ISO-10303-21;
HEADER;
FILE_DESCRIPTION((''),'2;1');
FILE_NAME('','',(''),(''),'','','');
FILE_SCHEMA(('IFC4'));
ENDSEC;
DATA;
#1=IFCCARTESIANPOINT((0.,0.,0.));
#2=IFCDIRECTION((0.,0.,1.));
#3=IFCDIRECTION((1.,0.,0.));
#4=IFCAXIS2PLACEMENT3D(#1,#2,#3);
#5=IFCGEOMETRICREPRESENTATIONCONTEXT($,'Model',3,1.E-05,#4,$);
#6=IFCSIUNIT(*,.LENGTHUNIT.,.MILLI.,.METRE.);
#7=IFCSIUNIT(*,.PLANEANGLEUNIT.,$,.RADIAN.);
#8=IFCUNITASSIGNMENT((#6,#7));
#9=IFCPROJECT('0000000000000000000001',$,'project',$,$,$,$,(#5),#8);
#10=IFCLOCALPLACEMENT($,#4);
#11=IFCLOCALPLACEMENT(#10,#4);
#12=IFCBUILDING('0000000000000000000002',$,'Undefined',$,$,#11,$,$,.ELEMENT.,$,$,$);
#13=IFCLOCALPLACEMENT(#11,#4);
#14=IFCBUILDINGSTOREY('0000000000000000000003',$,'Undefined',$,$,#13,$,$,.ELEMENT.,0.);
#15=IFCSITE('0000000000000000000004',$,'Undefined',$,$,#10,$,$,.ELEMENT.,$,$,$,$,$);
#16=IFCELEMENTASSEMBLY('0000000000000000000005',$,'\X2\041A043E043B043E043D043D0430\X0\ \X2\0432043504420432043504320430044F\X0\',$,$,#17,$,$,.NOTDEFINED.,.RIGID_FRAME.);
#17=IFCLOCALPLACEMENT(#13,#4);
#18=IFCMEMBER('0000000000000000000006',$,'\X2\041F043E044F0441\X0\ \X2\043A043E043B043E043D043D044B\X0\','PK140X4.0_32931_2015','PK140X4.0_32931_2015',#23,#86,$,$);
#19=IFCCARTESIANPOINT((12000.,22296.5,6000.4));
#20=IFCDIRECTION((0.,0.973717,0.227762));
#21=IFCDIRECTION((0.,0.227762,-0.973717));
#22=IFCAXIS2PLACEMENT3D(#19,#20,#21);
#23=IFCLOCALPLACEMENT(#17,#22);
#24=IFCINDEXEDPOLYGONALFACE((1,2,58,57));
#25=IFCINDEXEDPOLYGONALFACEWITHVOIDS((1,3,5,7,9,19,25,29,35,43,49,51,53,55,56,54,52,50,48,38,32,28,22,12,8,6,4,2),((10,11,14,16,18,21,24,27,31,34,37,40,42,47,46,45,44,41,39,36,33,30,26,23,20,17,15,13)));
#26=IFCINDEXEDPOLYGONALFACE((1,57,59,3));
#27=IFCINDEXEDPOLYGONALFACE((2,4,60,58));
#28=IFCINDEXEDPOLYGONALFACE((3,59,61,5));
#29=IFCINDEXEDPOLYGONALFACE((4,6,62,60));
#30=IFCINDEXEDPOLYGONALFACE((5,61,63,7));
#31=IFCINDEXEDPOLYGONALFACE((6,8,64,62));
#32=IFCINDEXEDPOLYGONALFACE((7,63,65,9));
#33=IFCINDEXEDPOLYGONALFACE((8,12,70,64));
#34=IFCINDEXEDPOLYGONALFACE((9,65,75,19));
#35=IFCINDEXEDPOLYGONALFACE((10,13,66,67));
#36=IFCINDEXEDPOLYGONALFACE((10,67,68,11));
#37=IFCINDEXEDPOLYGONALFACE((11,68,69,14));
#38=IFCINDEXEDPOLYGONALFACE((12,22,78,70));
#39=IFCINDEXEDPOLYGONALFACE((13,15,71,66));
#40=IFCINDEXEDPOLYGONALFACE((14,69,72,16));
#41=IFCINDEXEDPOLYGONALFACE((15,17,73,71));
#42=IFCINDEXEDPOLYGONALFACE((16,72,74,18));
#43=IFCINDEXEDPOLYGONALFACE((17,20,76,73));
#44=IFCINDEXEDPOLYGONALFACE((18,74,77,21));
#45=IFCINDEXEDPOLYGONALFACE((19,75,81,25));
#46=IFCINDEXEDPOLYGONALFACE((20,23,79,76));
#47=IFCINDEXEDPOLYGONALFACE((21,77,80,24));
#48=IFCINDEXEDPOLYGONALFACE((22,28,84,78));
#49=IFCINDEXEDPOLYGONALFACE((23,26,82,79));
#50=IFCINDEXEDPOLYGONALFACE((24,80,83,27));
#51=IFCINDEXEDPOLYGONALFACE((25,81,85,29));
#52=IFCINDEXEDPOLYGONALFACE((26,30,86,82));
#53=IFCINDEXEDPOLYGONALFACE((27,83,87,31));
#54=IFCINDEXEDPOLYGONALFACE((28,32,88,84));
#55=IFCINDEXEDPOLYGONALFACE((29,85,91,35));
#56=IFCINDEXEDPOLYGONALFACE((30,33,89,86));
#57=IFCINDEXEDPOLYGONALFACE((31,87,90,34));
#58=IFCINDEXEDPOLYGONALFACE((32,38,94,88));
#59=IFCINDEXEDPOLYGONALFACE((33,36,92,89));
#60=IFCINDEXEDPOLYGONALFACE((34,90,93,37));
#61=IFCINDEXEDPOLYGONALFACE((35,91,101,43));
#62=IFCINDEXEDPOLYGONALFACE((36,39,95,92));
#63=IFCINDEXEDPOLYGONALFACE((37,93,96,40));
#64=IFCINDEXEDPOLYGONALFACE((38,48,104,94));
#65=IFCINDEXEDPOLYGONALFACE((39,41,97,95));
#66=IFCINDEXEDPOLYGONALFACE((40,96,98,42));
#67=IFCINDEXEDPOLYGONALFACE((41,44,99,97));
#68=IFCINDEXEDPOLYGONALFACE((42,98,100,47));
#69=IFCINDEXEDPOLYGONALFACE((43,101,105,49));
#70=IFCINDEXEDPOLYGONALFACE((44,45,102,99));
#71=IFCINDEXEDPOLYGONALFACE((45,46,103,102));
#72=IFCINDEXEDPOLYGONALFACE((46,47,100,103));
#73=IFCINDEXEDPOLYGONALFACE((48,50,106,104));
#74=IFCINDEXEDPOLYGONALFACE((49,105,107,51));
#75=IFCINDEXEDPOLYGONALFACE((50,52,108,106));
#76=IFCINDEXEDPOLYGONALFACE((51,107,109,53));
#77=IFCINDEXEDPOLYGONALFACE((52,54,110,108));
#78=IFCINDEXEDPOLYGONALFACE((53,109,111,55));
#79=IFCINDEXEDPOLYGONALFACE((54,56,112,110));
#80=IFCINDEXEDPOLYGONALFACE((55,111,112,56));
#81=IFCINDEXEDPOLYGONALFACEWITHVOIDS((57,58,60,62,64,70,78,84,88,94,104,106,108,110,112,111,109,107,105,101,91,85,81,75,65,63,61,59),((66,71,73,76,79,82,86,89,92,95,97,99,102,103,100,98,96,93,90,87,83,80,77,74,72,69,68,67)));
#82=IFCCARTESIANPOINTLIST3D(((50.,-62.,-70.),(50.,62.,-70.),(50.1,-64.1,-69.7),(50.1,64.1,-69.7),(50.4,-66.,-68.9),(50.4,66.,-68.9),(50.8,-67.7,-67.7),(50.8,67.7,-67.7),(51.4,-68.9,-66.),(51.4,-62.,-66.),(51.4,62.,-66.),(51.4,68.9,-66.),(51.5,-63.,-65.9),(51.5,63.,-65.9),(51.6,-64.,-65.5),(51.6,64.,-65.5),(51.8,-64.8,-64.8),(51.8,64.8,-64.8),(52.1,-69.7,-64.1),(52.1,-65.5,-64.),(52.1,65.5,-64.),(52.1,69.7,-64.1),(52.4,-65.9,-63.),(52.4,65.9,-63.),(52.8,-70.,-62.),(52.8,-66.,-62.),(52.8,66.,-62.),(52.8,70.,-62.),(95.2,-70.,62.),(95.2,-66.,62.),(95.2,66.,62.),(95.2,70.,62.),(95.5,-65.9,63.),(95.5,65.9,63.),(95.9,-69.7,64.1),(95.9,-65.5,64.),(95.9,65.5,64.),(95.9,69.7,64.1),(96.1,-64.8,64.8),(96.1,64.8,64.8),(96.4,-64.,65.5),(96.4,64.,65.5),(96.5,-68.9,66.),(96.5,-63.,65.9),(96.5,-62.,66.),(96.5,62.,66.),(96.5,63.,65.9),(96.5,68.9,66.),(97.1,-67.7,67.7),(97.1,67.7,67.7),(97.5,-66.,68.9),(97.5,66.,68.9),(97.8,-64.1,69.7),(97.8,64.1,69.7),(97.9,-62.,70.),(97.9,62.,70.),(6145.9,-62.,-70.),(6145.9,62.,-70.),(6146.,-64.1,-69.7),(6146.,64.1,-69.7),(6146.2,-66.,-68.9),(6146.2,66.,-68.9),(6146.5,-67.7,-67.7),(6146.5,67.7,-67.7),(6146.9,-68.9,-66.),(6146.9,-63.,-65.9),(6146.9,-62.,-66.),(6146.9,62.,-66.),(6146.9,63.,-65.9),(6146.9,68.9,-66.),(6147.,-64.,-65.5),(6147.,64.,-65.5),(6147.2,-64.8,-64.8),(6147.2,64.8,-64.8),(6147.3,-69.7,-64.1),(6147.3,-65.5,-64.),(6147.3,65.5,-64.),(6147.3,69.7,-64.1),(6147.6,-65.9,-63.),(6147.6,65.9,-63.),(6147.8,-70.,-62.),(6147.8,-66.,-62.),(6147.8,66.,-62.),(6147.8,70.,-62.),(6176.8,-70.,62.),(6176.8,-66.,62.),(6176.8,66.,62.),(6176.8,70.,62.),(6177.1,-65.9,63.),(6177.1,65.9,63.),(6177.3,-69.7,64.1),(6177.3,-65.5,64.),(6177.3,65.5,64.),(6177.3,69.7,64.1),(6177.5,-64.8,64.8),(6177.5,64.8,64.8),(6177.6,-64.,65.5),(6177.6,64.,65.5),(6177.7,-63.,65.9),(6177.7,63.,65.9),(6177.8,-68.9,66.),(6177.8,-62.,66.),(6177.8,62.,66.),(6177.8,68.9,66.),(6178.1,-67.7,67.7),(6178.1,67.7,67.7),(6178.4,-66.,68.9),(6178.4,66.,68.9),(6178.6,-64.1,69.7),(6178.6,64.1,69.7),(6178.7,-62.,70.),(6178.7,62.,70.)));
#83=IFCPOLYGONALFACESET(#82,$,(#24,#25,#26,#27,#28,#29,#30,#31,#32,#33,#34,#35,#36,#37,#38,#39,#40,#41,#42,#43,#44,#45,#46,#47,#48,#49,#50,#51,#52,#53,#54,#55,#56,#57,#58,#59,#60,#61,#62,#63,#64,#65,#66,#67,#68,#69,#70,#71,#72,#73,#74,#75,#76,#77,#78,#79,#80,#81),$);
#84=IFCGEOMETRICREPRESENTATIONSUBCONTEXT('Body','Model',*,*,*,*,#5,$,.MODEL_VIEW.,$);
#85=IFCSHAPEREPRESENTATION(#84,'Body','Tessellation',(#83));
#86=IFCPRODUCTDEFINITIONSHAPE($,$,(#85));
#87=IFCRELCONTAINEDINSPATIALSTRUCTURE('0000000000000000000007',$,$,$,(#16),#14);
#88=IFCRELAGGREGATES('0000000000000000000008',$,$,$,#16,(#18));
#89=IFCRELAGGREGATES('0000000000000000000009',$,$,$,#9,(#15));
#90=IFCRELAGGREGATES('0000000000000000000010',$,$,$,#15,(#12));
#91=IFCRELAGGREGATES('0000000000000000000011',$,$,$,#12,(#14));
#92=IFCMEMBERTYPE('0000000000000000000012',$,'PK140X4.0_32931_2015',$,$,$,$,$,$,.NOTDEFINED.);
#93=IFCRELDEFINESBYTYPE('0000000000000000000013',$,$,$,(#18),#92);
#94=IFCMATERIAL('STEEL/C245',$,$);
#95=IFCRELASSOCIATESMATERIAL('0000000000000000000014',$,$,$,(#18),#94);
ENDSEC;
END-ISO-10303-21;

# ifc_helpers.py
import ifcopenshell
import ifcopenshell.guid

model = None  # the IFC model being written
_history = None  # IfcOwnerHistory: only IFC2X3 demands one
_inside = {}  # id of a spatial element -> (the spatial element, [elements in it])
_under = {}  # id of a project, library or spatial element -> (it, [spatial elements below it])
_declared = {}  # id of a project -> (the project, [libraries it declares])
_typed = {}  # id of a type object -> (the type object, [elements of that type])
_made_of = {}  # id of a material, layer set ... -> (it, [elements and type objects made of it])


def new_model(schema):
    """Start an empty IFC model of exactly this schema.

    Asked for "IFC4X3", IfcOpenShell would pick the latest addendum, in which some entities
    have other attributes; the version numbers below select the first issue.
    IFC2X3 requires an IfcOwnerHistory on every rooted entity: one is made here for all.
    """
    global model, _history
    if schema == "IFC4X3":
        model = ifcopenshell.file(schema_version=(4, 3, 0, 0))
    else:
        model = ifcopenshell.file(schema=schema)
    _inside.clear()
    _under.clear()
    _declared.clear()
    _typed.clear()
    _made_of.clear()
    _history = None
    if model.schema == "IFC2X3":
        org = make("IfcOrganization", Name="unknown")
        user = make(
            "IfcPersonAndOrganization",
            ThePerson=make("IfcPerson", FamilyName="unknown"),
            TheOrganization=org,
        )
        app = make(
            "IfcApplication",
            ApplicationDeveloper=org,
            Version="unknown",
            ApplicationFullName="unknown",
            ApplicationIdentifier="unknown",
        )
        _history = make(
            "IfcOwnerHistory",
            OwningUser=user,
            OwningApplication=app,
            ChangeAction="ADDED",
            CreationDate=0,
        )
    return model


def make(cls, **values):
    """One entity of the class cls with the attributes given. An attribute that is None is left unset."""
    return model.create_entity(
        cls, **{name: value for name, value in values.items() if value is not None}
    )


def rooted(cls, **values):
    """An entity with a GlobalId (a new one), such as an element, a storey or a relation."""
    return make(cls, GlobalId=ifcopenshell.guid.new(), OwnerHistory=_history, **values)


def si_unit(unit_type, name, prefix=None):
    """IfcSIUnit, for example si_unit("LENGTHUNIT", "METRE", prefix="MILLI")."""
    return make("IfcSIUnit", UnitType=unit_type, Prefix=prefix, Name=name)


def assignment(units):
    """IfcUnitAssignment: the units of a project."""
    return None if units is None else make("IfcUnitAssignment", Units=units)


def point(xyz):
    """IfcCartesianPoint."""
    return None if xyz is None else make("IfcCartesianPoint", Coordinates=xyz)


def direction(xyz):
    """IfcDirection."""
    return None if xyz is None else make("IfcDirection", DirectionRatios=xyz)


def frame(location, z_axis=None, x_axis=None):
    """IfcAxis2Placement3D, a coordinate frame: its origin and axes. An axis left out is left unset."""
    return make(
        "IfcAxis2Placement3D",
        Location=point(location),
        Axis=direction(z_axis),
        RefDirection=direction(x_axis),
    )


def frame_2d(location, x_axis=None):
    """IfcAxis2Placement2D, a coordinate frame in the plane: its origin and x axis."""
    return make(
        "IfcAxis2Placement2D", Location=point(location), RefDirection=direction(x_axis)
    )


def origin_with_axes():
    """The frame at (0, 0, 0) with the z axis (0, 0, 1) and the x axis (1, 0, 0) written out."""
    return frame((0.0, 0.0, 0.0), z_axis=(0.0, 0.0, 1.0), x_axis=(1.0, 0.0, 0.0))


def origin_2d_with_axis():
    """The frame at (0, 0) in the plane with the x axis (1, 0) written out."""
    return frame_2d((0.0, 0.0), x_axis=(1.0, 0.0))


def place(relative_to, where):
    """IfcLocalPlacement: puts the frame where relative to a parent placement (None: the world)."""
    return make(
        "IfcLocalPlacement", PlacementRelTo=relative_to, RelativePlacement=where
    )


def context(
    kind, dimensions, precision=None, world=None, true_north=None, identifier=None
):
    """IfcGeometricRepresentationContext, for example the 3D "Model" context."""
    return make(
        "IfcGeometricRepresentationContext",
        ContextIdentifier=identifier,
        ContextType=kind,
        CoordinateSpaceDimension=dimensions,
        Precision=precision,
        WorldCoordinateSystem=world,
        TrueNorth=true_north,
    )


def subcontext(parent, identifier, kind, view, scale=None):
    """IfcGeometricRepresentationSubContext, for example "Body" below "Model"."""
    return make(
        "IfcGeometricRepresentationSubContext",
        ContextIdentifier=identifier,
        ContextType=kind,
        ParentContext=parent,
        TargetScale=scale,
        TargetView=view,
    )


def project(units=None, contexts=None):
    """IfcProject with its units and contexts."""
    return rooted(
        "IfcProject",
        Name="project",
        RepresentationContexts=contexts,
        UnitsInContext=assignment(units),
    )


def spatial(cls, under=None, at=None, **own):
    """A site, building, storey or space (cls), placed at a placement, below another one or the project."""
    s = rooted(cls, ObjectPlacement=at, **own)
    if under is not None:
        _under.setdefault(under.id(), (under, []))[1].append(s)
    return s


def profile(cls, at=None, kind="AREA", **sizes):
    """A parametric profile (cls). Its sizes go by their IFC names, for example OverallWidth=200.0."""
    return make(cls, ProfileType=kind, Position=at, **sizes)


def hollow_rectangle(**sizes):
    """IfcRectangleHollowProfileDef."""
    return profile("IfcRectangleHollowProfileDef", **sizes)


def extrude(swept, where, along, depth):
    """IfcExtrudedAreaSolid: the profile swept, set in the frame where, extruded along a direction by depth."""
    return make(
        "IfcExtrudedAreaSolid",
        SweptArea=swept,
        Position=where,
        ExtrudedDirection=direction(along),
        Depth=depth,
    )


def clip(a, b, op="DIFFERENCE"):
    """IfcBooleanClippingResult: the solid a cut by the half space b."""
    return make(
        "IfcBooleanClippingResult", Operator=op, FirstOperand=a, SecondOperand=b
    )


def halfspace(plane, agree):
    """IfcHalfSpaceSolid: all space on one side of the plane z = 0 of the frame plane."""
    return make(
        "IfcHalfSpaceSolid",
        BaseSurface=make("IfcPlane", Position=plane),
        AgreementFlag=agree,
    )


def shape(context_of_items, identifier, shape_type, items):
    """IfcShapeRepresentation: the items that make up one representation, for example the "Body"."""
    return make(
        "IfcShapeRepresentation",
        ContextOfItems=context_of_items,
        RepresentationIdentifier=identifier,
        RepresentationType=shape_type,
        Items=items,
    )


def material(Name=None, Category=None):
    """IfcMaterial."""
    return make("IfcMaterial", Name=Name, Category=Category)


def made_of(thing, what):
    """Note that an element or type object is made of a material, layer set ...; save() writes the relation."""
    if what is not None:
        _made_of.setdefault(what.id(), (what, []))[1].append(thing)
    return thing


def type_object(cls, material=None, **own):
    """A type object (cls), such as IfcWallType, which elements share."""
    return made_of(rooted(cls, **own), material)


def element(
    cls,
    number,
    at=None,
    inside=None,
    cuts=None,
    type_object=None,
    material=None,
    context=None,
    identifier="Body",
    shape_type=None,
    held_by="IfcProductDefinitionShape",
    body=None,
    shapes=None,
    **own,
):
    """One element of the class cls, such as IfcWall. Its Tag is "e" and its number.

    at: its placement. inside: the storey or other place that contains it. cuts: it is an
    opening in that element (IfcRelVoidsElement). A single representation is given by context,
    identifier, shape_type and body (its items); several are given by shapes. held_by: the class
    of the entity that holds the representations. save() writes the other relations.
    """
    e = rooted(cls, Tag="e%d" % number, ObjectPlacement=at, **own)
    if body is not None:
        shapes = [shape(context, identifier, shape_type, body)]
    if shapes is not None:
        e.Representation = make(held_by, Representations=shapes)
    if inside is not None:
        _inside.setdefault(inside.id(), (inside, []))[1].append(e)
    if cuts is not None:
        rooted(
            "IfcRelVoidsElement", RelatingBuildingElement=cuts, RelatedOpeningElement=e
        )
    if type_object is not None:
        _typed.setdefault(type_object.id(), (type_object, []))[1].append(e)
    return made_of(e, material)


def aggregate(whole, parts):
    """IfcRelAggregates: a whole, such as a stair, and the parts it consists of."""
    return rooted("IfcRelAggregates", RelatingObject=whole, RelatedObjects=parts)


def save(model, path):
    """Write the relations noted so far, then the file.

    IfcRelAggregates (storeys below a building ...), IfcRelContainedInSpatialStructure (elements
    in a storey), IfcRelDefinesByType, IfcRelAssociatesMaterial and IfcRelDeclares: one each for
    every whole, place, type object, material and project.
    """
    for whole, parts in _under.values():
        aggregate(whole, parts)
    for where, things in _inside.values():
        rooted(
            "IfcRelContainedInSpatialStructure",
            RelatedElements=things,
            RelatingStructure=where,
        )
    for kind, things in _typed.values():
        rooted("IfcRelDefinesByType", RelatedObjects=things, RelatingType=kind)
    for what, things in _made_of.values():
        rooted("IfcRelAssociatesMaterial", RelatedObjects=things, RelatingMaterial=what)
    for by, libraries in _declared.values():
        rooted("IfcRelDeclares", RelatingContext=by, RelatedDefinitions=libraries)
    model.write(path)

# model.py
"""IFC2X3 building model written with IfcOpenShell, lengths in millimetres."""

from ifc_helpers import new_model, si_unit, frame, origin_with_axes, origin_2d_with_axis, place, context, subcontext, project, spatial, hollow_rectangle, extrude, clip, halfspace, material, type_object, element, aggregate, save


model = new_model("IFC2X3")

# Units and contexts
model_context = context("Model", 3, precision=1e-05, world=origin_with_axes())
body_context = subcontext(model_context, "Body", "Model", "MODEL_VIEW")
ifc_project = project(units=[si_unit("LENGTHUNIT", "METRE", prefix="MILLI"), si_unit("PLANEANGLEUNIT", "RADIAN")], contexts=[model_context])

# Site, building, storey
site_placement = place(None, origin_with_axes())
site = spatial("IfcSite", under=ifc_project, at=site_placement, Name="Undefined", CompositionType="ELEMENT")
building_placement = place(site_placement, origin_with_axes())
building = spatial("IfcBuilding", under=site, at=building_placement, Name="Undefined", CompositionType="ELEMENT")
storey_placement = place(building_placement, origin_with_axes())
storey = spatial("IfcBuildingStorey", under=building, at=storey_placement, Name="Undefined", CompositionType="ELEMENT", Elevation=0.0)

# Shared definitions
ifc_material_1 = material(Name="STEEL/C245")

# Element assembly
assembly_1_placement = place(storey_placement, origin_with_axes())
assembly_1 = element("IfcElementAssembly", 1, at=assembly_1_placement, inside=storey, Name="Колонна ветвевая", AssemblyPlace="NOTDEFINED", PredefinedType="RIGID_FRAME")

# Shared definitions
member_type_1 = type_object("IfcMemberType", Name="PK140X4.0_32931_2015", PredefinedType="NOTDEFINED")

# Member
member_1_placement = place(assembly_1_placement, frame((12000.0, 22296.5, 6000.4), z_axis=(0.0, 0.973717, 0.227762), x_axis=(0.0, 0.227762, -0.973717)))
member_1 = element("IfcMember", 2, at=member_1_placement, type_object=member_type_1, material=ifc_material_1, Name="Пояс колонны", Description="PK140X4.0_32931_2015", ObjectType="PK140X4.0_32931_2015", context=body_context, shape_type="Clipping", body=[
    clip(clip(extrude(hollow_rectangle(XDim=140.0, YDim=140.0, WallThickness=4.0, InnerFilletRadius=4.0, OuterFilletRadius=8.0, at=origin_2d_with_axis()), frame((6203.0, 0.0, 0.0), z_axis=(-1.0, 0.0, 0.0), x_axis=(0.0, -1.0, 0.0)), (0.0, 0.0, 1.0), 6169.8), halfspace(frame((6128.6, 0.0, -144.2), z_axis=(0.973717, 0.0, -0.227762), x_axis=(-0.227762, 0.0, -0.973717)), False)), halfspace(frame((33.3, 0.0, -119.0), z_axis=(-0.946221, 0.0, 0.32352), x_axis=(0.32352, 0.0, 0.946221)), False)),
])

aggregate(assembly_1, [member_1])

save(model, "model.ifc")
